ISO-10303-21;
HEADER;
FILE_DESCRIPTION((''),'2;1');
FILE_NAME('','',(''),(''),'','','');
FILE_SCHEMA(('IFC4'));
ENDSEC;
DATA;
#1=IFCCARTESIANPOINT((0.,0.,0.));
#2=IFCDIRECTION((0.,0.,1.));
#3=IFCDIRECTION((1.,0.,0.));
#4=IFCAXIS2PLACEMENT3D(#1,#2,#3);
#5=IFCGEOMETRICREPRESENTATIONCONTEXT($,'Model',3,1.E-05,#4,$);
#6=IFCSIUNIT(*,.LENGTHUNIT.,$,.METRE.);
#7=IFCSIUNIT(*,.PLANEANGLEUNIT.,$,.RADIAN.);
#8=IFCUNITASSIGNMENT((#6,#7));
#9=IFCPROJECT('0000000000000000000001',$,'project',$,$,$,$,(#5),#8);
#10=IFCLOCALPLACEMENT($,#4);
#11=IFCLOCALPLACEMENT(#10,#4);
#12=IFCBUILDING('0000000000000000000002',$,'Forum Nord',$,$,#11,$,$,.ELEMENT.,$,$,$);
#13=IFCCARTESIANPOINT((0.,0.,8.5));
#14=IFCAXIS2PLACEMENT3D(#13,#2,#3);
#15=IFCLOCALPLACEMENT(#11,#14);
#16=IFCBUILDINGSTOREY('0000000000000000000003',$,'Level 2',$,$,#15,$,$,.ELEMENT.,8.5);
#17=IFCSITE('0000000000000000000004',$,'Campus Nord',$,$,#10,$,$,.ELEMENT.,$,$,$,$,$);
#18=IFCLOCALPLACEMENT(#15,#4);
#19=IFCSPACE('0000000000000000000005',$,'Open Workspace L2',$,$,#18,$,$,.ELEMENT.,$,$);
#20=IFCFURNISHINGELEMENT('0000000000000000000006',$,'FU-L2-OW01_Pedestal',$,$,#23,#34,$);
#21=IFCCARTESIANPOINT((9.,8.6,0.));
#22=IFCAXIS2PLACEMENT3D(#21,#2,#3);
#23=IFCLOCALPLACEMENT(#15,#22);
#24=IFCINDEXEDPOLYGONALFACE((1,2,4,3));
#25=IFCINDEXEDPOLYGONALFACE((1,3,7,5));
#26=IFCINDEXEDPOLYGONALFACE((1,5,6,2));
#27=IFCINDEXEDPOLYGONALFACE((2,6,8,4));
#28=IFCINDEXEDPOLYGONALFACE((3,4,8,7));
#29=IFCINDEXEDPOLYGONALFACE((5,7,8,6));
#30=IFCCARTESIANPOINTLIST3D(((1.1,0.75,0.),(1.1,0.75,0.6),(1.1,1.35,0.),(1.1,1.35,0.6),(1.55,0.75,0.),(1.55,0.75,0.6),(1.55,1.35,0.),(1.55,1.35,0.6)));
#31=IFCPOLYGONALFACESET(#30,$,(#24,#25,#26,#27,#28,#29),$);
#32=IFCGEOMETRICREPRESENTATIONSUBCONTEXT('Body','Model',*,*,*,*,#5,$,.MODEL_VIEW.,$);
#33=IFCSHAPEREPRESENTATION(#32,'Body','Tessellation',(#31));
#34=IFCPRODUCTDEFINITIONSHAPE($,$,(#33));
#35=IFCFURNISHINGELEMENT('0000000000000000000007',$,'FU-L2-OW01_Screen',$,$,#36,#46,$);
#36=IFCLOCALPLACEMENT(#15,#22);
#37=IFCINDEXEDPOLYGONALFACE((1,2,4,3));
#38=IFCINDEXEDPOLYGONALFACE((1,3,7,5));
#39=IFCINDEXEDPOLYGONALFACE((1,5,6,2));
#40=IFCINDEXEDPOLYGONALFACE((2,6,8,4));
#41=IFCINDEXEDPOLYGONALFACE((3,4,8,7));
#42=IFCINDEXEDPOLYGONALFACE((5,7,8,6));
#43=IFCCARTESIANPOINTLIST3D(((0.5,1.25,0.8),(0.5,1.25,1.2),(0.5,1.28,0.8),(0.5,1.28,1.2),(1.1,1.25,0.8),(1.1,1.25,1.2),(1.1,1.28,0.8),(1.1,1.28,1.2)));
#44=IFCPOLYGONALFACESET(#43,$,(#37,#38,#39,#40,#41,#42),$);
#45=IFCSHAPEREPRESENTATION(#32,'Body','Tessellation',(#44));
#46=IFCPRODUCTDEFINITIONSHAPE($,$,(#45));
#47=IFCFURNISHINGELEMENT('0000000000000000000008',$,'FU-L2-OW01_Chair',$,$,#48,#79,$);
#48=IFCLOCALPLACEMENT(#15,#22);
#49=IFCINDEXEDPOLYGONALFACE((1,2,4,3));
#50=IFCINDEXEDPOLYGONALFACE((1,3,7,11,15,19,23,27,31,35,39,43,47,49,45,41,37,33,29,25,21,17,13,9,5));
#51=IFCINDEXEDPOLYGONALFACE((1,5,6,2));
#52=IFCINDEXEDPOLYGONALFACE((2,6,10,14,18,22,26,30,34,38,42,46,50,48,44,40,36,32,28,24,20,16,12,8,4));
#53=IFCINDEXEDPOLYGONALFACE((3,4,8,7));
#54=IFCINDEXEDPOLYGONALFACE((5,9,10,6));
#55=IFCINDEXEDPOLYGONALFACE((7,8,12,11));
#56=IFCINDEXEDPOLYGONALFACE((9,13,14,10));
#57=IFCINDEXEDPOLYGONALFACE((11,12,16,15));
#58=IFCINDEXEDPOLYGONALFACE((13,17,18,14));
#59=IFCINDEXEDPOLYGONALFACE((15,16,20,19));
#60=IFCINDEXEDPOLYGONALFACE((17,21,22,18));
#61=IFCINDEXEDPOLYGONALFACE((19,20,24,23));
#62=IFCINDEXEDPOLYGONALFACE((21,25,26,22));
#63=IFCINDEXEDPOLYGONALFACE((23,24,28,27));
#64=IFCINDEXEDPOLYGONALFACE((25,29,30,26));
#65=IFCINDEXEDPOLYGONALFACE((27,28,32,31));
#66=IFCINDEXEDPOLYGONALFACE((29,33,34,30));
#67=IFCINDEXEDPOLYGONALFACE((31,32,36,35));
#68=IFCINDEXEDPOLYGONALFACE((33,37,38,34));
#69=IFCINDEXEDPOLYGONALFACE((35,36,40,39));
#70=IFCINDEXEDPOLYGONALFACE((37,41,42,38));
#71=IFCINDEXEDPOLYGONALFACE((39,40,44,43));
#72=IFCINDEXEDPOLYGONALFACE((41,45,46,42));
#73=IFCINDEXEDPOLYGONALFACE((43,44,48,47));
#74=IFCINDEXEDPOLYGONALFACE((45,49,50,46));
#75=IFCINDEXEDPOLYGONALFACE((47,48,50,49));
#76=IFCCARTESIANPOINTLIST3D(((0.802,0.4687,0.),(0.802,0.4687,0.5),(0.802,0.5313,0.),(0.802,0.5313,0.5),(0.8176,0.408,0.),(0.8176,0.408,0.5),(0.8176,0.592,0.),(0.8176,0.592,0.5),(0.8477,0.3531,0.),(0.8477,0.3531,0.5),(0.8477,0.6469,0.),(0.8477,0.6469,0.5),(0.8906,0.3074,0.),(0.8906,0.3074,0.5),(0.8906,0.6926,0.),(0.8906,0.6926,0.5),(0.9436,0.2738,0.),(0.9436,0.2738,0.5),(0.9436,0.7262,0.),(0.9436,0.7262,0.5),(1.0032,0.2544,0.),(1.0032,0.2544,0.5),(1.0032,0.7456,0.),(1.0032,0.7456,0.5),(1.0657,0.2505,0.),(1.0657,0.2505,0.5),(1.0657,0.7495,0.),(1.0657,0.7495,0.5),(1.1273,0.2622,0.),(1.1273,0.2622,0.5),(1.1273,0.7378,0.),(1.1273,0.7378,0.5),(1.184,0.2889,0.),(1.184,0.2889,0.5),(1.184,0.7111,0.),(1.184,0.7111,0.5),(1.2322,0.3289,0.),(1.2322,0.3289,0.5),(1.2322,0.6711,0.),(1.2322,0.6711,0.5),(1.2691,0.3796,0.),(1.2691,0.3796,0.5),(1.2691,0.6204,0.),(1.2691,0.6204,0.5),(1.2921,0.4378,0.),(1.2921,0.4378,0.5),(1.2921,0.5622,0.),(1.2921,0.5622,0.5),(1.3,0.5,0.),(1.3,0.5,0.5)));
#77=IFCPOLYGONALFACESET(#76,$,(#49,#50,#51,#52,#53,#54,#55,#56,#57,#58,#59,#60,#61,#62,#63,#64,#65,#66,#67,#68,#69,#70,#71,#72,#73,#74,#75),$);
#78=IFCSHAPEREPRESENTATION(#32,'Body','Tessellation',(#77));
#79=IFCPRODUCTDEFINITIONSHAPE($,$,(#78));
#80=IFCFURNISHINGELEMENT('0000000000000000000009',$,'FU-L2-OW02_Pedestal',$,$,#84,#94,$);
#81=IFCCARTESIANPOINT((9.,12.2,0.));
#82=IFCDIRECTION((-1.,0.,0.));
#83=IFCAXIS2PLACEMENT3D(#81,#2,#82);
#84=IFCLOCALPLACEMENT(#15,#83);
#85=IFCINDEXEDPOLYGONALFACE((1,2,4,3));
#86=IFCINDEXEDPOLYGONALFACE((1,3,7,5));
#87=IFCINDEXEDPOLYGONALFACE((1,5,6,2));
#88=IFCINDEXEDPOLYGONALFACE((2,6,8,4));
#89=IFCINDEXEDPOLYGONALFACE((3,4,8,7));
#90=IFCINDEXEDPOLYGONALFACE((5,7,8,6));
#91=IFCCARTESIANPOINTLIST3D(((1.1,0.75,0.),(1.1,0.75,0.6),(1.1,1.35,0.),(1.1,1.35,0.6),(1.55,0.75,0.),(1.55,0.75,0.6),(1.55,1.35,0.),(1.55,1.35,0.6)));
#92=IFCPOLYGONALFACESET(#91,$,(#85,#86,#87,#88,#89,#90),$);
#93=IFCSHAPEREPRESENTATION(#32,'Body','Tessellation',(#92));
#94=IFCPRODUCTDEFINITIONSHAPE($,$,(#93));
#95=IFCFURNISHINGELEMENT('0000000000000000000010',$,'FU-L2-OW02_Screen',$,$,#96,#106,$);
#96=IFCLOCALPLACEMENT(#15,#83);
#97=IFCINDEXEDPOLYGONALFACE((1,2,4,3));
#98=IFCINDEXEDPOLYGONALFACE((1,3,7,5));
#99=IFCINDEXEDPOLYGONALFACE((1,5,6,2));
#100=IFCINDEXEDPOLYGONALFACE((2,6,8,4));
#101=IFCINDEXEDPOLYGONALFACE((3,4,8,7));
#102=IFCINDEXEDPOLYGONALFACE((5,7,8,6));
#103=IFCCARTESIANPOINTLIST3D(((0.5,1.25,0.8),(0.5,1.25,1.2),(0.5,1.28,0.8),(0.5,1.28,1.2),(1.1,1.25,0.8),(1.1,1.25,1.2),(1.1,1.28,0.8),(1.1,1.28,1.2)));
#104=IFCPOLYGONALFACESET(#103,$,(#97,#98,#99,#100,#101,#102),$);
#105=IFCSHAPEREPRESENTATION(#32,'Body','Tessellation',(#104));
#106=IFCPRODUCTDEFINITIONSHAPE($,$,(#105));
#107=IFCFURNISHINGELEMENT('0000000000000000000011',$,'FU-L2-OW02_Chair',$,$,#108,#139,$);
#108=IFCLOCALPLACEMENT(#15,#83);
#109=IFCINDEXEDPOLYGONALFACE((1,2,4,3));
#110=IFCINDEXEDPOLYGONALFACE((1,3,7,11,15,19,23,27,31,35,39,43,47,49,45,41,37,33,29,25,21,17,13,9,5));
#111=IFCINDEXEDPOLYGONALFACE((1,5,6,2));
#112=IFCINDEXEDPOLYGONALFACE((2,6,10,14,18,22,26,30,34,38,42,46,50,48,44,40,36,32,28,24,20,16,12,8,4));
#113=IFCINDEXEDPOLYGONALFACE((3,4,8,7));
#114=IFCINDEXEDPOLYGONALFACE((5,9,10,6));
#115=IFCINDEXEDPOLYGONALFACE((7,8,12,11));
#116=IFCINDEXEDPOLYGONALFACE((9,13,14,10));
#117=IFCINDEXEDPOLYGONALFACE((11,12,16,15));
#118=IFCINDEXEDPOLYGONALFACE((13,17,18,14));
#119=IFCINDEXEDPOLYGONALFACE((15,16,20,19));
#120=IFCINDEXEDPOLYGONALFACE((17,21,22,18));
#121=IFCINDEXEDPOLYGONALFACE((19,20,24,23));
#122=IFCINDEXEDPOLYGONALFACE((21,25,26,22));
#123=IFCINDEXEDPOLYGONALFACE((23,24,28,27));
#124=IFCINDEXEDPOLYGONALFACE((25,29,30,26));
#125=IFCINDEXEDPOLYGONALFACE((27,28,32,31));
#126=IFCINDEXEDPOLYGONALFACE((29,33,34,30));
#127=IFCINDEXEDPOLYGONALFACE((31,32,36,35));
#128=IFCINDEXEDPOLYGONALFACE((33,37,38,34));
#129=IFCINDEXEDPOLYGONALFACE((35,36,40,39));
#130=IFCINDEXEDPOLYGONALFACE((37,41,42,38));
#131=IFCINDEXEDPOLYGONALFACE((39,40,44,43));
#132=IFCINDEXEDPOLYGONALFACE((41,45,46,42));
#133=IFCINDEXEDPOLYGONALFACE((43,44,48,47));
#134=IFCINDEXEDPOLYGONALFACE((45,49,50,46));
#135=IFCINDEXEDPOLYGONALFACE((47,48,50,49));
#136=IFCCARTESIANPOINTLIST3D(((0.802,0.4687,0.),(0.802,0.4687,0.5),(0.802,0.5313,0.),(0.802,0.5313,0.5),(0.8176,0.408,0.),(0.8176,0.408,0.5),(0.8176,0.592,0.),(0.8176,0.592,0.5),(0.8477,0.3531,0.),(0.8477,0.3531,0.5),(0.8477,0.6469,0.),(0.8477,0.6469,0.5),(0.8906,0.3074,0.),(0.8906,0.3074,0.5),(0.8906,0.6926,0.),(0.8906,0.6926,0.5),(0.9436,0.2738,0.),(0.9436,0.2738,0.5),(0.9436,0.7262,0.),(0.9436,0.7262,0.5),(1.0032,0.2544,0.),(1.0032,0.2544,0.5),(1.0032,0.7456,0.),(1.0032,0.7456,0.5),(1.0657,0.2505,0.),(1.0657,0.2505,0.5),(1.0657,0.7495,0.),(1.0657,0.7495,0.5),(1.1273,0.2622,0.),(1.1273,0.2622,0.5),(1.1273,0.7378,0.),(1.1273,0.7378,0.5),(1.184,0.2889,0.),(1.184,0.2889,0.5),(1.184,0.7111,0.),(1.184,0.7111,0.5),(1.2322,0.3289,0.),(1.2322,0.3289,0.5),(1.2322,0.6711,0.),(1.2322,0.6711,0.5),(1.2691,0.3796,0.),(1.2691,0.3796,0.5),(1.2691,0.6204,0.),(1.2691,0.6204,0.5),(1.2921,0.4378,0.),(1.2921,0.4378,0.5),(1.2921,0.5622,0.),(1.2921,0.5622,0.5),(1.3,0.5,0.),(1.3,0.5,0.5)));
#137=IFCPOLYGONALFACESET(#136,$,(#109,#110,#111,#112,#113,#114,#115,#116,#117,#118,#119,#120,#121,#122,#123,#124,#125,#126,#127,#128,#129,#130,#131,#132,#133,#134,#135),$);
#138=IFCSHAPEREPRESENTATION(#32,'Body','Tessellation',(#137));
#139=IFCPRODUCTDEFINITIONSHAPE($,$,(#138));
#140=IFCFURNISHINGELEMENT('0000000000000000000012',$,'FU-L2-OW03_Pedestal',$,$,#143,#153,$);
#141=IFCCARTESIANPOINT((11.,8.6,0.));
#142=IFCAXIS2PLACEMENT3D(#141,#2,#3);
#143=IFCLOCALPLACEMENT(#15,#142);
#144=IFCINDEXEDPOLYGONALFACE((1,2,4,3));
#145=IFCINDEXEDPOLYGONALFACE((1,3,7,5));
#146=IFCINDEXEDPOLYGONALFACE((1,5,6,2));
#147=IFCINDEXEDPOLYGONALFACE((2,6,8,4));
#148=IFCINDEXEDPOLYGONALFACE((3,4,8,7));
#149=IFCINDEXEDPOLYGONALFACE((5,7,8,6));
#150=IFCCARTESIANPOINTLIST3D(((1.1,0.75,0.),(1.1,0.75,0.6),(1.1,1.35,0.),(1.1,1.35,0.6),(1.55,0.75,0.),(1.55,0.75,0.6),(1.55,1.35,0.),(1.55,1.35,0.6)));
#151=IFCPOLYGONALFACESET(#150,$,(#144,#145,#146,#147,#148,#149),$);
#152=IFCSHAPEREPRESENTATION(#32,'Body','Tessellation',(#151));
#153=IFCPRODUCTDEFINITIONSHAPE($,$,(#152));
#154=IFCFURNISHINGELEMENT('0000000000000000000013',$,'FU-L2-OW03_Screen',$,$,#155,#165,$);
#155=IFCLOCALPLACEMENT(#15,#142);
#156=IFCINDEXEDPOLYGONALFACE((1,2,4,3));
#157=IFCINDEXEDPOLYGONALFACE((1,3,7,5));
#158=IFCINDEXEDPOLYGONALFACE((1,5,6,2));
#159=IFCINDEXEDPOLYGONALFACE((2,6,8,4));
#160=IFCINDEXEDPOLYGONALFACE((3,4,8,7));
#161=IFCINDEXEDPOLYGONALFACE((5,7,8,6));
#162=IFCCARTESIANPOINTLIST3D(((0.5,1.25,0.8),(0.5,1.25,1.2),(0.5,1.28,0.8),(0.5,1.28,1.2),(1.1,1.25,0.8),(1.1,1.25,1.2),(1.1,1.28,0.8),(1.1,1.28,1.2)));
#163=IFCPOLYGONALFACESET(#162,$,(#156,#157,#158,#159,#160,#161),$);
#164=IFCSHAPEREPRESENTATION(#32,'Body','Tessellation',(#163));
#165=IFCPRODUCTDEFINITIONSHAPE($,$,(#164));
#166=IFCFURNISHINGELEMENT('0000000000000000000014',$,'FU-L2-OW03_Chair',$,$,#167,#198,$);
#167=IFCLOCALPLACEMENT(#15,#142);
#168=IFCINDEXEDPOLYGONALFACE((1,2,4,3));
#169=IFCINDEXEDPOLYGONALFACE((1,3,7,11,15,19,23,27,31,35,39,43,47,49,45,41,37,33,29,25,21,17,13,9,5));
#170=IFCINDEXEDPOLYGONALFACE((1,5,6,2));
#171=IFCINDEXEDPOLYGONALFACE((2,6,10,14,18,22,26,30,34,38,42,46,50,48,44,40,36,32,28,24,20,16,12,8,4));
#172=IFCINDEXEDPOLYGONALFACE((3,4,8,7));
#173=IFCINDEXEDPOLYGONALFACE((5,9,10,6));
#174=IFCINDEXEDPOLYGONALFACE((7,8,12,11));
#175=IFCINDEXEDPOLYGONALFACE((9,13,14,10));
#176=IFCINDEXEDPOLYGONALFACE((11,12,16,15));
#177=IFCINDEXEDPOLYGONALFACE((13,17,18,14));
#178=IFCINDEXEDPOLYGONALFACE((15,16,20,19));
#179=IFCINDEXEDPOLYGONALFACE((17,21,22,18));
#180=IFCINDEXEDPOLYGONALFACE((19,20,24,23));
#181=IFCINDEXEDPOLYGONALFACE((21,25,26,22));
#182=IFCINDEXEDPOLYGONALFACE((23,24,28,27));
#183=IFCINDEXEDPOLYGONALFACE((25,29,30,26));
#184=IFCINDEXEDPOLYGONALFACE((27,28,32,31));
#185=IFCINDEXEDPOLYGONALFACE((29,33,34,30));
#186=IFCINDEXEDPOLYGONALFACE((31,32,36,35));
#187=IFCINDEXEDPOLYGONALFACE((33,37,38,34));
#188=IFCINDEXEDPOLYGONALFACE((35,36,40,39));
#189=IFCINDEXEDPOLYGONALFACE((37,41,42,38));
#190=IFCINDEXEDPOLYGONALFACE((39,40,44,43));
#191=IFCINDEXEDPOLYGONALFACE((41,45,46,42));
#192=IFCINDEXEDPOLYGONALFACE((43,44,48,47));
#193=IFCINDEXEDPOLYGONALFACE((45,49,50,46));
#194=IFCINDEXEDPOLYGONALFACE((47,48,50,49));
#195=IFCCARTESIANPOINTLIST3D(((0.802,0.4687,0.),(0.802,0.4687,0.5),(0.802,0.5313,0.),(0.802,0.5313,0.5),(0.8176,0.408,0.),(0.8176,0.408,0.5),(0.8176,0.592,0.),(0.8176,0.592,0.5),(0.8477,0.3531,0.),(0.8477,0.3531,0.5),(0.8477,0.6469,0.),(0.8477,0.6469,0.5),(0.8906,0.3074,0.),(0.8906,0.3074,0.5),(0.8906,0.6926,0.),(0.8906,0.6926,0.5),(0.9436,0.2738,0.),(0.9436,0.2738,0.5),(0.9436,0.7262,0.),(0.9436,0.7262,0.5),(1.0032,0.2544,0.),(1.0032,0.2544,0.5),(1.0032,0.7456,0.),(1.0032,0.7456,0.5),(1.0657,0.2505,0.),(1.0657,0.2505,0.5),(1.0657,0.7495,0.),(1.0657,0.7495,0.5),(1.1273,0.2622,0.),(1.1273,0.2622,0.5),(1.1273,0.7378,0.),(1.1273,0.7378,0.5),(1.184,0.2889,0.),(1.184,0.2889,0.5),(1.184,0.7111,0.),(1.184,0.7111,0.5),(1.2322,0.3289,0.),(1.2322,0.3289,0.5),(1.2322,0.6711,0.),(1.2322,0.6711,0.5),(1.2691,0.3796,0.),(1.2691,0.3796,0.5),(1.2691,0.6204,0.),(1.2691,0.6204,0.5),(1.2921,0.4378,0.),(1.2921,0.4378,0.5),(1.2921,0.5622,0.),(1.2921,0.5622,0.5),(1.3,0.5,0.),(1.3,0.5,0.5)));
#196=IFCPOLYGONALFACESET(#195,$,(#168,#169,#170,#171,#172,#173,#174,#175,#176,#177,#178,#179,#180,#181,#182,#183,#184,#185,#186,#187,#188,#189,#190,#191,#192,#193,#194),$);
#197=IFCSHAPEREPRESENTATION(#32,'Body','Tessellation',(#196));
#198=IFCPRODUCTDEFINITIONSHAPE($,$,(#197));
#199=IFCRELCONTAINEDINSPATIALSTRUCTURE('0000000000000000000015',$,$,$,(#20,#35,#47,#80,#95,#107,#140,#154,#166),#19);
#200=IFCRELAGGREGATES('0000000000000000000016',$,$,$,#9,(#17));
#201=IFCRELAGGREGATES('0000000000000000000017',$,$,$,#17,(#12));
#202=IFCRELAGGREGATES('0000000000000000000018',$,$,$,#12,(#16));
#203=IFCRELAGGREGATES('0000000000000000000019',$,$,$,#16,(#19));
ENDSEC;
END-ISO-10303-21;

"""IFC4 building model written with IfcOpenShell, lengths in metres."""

from ifc_helpers import new_model, si_unit, frame, frame_2d, origin_with_axes, place, context, subcontext, project, spatial, rectangle, circle, extrude, element, save


model = new_model("IFC4")

# Units and contexts
model_context = context("Model", 3, precision=1e-05, world=origin_with_axes())
body_context = subcontext(model_context, "Body", "Model", "MODEL_VIEW")
ifc_project = project(units=[si_unit("LENGTHUNIT", "METRE"), si_unit("PLANEANGLEUNIT", "RADIAN")], contexts=[model_context])

# Site, building, storey, space
site_placement = place(None, origin_with_axes())
site = spatial("IfcSite", under=ifc_project, at=site_placement, Name="Campus Nord", CompositionType="ELEMENT")
building_placement = place(site_placement, origin_with_axes())
building = spatial("IfcBuilding", under=site, at=building_placement, Name="Forum Nord", CompositionType="ELEMENT")
storey_placement = place(building_placement, frame((0.0, 0.0, 8.5), z_axis=(0.0, 0.0, 1.0), x_axis=(1.0, 0.0, 0.0)))
storey = spatial("IfcBuildingStorey", under=building, at=storey_placement, Name="Level 2", CompositionType="ELEMENT", Elevation=8.5)
space_placement = place(storey_placement, origin_with_axes())
space = spatial("IfcSpace", under=storey, at=space_placement, Name="Open Workspace L2", CompositionType="ELEMENT")

# Furnishing elements
furnishing_1_placement = place(storey_placement, frame((9.0, 8.6, 0.0), z_axis=(0.0, 0.0, 1.0), x_axis=(1.0, 0.0, 0.0)))
element("IfcFurnishingElement", 1, at=furnishing_1_placement, inside=space, Name="FU-L2-OW01_Pedestal", context=body_context, shape_type="SweptSolid", body=[
    extrude(rectangle(XDim=0.45, YDim=0.6, at=frame_2d((1.325, 1.05), x_axis=(1.0, 0.0))), origin_with_axes(), (0.0, 0.0, 1.0), 0.6),
])
furnishing_2_placement = place(storey_placement, frame((9.0, 8.6, 0.0), z_axis=(0.0, 0.0, 1.0), x_axis=(1.0, 0.0, 0.0)))
element("IfcFurnishingElement", 2, at=furnishing_2_placement, inside=space, Name="FU-L2-OW01_Screen", context=body_context, shape_type="SweptSolid", body=[
    extrude(rectangle(XDim=0.6, YDim=0.03, at=frame_2d((0.8, 1.265), x_axis=(1.0, 0.0))), frame((0.0, 0.0, 0.8), z_axis=(0.0, 0.0, 1.0), x_axis=(1.0, 0.0, 0.0)), (0.0, 0.0, 1.0), 0.4),
])
furnishing_3_placement = place(storey_placement, frame((9.0, 8.6, 0.0), z_axis=(0.0, 0.0, 1.0), x_axis=(1.0, 0.0, 0.0)))
element("IfcFurnishingElement", 3, at=furnishing_3_placement, inside=space, Name="FU-L2-OW01_Chair", context=body_context, shape_type="SweptSolid", body=[
    extrude(circle(Radius=0.25, at=frame_2d((1.05, 0.5), x_axis=(1.0, 0.0))), origin_with_axes(), (0.0, 0.0, 1.0), 0.5),
])
furnishing_4_placement = place(storey_placement, frame((9.0, 12.2, 0.0), z_axis=(0.0, 0.0, 1.0), x_axis=(-1.0, 0.0, 0.0)))
element("IfcFurnishingElement", 4, at=furnishing_4_placement, inside=space, Name="FU-L2-OW02_Pedestal", context=body_context, shape_type="SweptSolid", body=[
    extrude(rectangle(XDim=0.45, YDim=0.6, at=frame_2d((1.325, 1.05), x_axis=(1.0, 0.0))), origin_with_axes(), (0.0, 0.0, 1.0), 0.6),
])
furnishing_5_placement = place(storey_placement, frame((9.0, 12.2, 0.0), z_axis=(0.0, 0.0, 1.0), x_axis=(-1.0, 0.0, 0.0)))
element("IfcFurnishingElement", 5, at=furnishing_5_placement, inside=space, Name="FU-L2-OW02_Screen", context=body_context, shape_type="SweptSolid", body=[
    extrude(rectangle(XDim=0.6, YDim=0.03, at=frame_2d((0.8, 1.265), x_axis=(1.0, 0.0))), frame((0.0, 0.0, 0.8), z_axis=(0.0, 0.0, 1.0), x_axis=(1.0, 0.0, 0.0)), (0.0, 0.0, 1.0), 0.4),
])
furnishing_6_placement = place(storey_placement, frame((9.0, 12.2, 0.0), z_axis=(0.0, 0.0, 1.0), x_axis=(-1.0, 0.0, 0.0)))
element("IfcFurnishingElement", 6, at=furnishing_6_placement, inside=space, Name="FU-L2-OW02_Chair", context=body_context, shape_type="SweptSolid", body=[
    extrude(circle(Radius=0.25, at=frame_2d((1.05, 0.5), x_axis=(1.0, 0.0))), origin_with_axes(), (0.0, 0.0, 1.0), 0.5),
])
furnishing_7_placement = place(storey_placement, frame((11.0, 8.6, 0.0), z_axis=(0.0, 0.0, 1.0), x_axis=(1.0, 0.0, 0.0)))
element("IfcFurnishingElement", 7, at=furnishing_7_placement, inside=space, Name="FU-L2-OW03_Pedestal", context=body_context, shape_type="SweptSolid", body=[
    extrude(rectangle(XDim=0.45, YDim=0.6, at=frame_2d((1.325, 1.05), x_axis=(1.0, 0.0))), origin_with_axes(), (0.0, 0.0, 1.0), 0.6),
])
furnishing_8_placement = place(storey_placement, frame((11.0, 8.6, 0.0), z_axis=(0.0, 0.0, 1.0), x_axis=(1.0, 0.0, 0.0)))
element("IfcFurnishingElement", 8, at=furnishing_8_placement, inside=space, Name="FU-L2-OW03_Screen", context=body_context, shape_type="SweptSolid", body=[
    extrude(rectangle(XDim=0.6, YDim=0.03, at=frame_2d((0.8, 1.265), x_axis=(1.0, 0.0))), frame((0.0, 0.0, 0.8), z_axis=(0.0, 0.0, 1.0), x_axis=(1.0, 0.0, 0.0)), (0.0, 0.0, 1.0), 0.4),
])
furnishing_9_placement = place(storey_placement, frame((11.0, 8.6, 0.0), z_axis=(0.0, 0.0, 1.0), x_axis=(1.0, 0.0, 0.0)))
element("IfcFurnishingElement", 9, at=furnishing_9_placement, inside=space, Name="FU-L2-OW03_Chair", context=body_context, shape_type="SweptSolid", body=[
    extrude(circle(Radius=0.25, at=frame_2d((1.05, 0.5), x_axis=(1.0, 0.0))), origin_with_axes(), (0.0, 0.0, 1.0), 0.5),
])

save(model, "model.ifc")
